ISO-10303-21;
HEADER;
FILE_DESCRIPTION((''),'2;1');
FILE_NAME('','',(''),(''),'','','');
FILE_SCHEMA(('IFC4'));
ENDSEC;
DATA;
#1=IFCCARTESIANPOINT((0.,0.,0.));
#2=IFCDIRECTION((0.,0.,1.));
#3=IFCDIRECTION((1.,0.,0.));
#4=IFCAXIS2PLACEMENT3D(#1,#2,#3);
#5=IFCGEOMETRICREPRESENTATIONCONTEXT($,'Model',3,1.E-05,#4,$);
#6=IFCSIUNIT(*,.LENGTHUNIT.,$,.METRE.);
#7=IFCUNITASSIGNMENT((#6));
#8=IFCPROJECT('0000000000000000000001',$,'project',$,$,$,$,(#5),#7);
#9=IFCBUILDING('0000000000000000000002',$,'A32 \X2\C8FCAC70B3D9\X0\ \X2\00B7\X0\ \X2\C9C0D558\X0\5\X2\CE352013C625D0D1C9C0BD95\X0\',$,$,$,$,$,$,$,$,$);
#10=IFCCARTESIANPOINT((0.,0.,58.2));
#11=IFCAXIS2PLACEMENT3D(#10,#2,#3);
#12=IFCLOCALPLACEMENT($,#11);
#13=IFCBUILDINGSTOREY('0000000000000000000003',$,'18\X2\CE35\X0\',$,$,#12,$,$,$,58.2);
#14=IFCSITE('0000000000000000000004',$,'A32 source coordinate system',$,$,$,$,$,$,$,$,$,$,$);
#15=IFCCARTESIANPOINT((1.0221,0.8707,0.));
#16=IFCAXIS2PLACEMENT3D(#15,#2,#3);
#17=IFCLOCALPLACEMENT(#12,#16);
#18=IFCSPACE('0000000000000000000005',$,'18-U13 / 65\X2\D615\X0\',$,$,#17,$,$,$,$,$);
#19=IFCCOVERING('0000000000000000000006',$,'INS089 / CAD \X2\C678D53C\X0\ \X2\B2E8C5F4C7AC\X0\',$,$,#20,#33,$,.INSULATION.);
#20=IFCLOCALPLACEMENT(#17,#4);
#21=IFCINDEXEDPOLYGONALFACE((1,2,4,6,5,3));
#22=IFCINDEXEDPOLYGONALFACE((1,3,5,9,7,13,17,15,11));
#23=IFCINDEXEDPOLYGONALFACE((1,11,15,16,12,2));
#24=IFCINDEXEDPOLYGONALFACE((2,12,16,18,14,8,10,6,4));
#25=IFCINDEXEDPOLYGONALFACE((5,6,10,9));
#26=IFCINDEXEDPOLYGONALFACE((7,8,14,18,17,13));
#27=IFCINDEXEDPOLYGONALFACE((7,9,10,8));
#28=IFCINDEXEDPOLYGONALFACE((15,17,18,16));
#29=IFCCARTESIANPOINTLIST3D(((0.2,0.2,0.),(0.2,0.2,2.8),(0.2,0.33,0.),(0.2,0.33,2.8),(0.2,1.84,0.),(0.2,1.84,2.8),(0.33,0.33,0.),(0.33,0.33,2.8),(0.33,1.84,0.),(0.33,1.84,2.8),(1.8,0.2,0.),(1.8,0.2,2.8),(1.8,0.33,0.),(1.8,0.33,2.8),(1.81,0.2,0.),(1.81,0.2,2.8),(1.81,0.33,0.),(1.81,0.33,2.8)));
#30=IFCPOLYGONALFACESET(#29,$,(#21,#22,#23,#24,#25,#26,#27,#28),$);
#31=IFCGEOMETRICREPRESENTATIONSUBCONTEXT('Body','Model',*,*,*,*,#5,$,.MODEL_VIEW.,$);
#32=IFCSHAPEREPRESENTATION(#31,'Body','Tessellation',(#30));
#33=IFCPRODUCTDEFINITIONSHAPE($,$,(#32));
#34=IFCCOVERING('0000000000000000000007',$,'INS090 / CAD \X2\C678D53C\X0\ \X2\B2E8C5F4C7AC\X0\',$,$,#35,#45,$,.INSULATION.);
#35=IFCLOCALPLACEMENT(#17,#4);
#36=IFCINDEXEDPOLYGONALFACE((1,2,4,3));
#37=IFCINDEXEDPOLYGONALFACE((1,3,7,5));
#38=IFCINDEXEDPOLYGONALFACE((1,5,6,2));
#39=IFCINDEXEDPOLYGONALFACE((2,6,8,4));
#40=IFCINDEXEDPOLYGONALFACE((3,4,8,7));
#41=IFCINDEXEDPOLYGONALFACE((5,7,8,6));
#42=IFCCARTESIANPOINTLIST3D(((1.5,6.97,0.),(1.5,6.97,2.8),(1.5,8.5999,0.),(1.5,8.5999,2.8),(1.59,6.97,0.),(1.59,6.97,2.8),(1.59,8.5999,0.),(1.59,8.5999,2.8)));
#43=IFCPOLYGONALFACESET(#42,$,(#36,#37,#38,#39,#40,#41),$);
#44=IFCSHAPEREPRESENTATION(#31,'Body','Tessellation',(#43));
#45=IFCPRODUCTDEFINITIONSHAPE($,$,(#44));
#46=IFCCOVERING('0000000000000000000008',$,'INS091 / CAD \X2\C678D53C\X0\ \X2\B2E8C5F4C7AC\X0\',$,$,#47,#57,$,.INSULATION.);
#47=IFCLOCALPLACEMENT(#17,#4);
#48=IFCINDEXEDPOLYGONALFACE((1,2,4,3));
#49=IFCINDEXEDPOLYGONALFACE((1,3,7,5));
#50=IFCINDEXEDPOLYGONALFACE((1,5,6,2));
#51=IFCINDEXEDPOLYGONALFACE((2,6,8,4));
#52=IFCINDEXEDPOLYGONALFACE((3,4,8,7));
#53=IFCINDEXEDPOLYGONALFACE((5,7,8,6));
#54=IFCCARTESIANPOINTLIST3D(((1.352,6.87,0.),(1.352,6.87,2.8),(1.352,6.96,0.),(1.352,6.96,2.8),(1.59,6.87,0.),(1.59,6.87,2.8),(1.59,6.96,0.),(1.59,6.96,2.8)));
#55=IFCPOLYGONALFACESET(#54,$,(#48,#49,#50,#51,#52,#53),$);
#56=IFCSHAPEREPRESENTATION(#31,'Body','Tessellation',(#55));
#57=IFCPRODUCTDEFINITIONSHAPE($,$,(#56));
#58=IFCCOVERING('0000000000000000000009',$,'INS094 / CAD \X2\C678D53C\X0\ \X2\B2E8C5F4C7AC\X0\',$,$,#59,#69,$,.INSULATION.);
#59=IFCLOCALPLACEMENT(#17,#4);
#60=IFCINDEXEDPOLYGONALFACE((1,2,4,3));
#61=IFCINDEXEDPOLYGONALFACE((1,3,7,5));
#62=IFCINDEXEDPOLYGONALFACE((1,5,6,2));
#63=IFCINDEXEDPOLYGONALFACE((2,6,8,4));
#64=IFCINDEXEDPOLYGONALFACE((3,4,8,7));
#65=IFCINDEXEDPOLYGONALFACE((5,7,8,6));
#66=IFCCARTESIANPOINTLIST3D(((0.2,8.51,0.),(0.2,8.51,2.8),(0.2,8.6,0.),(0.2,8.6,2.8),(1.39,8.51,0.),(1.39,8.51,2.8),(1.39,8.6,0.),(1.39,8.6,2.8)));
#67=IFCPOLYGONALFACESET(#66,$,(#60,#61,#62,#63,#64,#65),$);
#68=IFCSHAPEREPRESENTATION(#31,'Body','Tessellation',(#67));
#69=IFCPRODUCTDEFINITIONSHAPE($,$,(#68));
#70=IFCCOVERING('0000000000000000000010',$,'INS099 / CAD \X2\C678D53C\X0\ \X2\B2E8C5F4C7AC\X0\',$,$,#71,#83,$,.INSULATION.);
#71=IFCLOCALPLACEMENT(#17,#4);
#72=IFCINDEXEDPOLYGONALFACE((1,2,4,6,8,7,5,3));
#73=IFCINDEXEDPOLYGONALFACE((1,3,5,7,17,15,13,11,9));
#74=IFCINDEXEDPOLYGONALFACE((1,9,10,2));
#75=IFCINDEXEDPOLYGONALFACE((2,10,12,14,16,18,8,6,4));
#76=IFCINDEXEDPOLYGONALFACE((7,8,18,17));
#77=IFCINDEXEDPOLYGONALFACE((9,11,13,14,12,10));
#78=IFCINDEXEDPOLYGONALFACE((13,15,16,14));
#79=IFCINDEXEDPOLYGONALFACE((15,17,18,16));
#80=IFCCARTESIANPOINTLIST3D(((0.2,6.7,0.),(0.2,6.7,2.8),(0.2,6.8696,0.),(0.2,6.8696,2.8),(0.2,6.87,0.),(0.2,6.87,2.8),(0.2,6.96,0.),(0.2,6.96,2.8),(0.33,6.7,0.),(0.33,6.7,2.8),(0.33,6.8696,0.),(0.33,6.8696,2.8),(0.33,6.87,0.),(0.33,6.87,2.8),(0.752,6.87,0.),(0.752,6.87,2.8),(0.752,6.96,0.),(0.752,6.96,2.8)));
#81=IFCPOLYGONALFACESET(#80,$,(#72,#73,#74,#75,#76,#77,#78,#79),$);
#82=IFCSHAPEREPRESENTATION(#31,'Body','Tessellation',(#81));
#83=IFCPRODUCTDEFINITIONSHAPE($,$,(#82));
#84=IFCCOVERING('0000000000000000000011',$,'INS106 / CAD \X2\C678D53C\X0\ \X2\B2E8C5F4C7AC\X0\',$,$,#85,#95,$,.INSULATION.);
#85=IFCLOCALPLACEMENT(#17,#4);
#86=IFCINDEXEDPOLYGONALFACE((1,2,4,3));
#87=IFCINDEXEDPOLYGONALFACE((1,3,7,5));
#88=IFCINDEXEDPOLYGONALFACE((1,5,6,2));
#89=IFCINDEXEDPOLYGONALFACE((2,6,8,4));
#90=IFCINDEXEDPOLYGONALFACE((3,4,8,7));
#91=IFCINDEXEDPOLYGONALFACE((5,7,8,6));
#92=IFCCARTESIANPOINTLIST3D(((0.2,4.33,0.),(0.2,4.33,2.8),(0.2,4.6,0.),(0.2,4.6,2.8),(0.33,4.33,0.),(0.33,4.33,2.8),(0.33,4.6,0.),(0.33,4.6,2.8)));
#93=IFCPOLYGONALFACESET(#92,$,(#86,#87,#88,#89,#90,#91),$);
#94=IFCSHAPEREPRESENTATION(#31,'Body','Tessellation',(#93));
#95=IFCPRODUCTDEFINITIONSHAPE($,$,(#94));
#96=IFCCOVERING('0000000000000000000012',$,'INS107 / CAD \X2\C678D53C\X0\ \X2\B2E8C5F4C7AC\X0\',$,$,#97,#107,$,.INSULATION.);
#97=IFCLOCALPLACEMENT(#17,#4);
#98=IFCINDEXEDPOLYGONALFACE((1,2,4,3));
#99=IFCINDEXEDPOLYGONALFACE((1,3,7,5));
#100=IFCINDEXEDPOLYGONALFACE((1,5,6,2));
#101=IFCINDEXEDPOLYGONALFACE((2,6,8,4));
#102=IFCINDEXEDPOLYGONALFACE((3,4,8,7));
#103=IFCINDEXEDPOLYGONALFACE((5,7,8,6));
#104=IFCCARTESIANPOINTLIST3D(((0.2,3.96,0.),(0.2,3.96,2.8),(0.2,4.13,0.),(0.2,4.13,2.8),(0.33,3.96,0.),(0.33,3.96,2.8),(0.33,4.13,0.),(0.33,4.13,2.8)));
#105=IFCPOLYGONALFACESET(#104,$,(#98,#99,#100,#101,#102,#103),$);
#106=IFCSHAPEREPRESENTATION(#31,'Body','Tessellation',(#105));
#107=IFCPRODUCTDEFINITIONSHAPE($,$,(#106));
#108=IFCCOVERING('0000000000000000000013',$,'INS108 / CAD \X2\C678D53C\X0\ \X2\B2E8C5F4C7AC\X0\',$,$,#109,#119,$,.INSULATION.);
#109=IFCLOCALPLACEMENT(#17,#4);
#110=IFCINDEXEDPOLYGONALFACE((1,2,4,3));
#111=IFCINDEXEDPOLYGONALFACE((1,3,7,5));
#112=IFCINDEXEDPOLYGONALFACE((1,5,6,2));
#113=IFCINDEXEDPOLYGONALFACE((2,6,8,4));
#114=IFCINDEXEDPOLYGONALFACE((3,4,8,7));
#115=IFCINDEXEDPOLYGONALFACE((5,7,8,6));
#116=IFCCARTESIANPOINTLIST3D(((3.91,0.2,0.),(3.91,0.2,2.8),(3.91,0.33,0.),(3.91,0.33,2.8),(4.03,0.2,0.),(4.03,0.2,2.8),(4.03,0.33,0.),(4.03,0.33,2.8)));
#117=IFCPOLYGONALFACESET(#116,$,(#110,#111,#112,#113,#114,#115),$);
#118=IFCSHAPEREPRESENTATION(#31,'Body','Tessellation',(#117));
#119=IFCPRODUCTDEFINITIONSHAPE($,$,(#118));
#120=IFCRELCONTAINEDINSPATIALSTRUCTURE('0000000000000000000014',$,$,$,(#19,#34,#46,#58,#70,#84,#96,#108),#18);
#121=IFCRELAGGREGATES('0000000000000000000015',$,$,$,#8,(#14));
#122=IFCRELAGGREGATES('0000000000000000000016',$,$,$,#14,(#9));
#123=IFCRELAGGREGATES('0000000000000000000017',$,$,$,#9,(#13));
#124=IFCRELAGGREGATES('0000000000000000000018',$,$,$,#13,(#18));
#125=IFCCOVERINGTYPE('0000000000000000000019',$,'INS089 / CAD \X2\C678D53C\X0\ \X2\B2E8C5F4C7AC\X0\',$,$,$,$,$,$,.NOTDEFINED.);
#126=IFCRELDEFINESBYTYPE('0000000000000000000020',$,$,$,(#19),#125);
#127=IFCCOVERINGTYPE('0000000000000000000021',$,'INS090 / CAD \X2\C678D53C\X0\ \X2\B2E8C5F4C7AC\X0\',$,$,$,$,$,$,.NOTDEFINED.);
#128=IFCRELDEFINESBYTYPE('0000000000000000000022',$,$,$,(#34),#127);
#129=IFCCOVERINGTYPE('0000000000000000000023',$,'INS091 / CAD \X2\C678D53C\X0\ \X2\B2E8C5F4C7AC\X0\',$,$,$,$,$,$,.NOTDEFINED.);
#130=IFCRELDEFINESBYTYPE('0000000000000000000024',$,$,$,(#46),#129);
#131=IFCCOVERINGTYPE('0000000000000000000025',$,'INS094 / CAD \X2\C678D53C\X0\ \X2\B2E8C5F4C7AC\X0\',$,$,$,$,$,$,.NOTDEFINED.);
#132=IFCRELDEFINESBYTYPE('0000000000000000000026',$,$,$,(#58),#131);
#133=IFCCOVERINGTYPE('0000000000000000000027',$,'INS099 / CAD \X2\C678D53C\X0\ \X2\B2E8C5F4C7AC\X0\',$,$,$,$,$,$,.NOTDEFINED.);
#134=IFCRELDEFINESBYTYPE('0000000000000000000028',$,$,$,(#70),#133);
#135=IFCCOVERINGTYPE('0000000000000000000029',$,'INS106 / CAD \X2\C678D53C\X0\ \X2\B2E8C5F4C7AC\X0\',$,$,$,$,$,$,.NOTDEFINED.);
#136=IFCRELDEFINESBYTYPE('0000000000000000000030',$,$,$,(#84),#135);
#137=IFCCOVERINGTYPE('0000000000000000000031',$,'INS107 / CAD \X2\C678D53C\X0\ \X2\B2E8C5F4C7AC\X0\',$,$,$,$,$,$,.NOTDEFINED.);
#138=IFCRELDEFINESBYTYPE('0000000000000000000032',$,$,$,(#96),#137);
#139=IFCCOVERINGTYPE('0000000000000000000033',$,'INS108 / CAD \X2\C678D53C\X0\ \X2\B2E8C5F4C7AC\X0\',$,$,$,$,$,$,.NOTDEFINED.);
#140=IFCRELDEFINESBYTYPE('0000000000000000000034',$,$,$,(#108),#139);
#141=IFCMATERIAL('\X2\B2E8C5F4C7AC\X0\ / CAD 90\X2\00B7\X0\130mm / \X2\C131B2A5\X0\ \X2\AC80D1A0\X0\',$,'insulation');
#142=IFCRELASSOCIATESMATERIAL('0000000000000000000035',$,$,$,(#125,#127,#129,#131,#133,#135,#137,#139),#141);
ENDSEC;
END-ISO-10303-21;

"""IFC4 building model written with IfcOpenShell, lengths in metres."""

from ifc_helpers import new_model, si_unit, frame, origin, origin_with_axes, place, context, subcontext, project, spatial, polyline, outline, extrude, source, transform, mapped, material, type_object, type_shapes, element, save


model = new_model("IFC4")

# Units and contexts
model_context = context("Model", 3, precision=1e-05, world=origin_with_axes())
body_context = subcontext(model_context, "Body", "Model", "MODEL_VIEW")
ifc_project = project(units=[si_unit("LENGTHUNIT", "METRE")], contexts=[model_context])

# Site, building, storey
site = spatial("IfcSite", under=ifc_project, Name="A32 source coordinate system")
building = spatial("IfcBuilding", under=site, Name="A32 주거동 · 지하5층–옥탑지붕")
storey_placement = place(None, frame((0.0, 0.0, 58.2), z_axis=(0.0, 0.0, 1.0), x_axis=(1.0, 0.0, 0.0)))
storey = spatial("IfcBuildingStorey", under=building, at=storey_placement, Name="18층", Elevation=58.2)

# Shared definitions
space_placement = place(storey_placement, frame((1.0221, 0.8707, 0.0), z_axis=(0.0, 0.0, 1.0), x_axis=(1.0, 0.0, 0.0)))
space = spatial("IfcSpace", under=storey, at=space_placement, Name="18-U13 / 65형")

# Coverings
ifc_material = material(Name="단열재 / CAD 90·130mm / 성능 검토", Category="insulation")
covering_type_1 = type_object("IfcCoveringType", Name="INS089 / CAD 외피 단열재", PredefinedType="NOTDEFINED", material=ifc_material)
shared_shape_1 = source(origin(), body_context, "Body", "SweptSolid", [
    extrude(outline(polyline([(0.2, 0.33), (0.2, 1.84), (0.33, 1.84), (0.33, 0.33), (1.8, 0.33), (1.81, 0.33), (1.81, 0.2), (1.8, 0.2), (0.2, 0.2), (0.2, 0.33)])), origin(), (0.0, 0.0, 1.0), 2.8),
])
type_shapes(covering_type_1, [shared_shape_1])
covering_1_placement = place(space_placement, origin_with_axes())
element("IfcCovering", 1, at=covering_1_placement, inside=space, type_object=covering_type_1, Name="INS089 / CAD 외피 단열재", PredefinedType="INSULATION", context=body_context, shape_type="MappedRepresentation", body=[
    mapped(shared_shape_1, transform((0.0, 0.0, 0.0), scale=1.0)),
])
covering_type_2 = type_object("IfcCoveringType", Name="INS090 / CAD 외피 단열재", PredefinedType="NOTDEFINED", material=ifc_material)
shared_shape_2 = source(origin(), body_context, "Body", "SweptSolid", [
    extrude(outline(polyline([(1.59, 6.97), (1.5, 6.97), (1.5, 8.5999), (1.59, 8.5999), (1.59, 6.97)])), origin(), (0.0, 0.0, 1.0), 2.8),
])
type_shapes(covering_type_2, [shared_shape_2])
covering_2_placement = place(space_placement, origin_with_axes())
element("IfcCovering", 2, at=covering_2_placement, inside=space, type_object=covering_type_2, Name="INS090 / CAD 외피 단열재", PredefinedType="INSULATION", context=body_context, shape_type="MappedRepresentation", body=[
    mapped(shared_shape_2, transform((0.0, 0.0, 0.0), scale=1.0)),
])
covering_type_3 = type_object("IfcCoveringType", Name="INS091 / CAD 외피 단열재", PredefinedType="NOTDEFINED", material=ifc_material)
shared_shape_3 = source(origin(), body_context, "Body", "SweptSolid", [
    extrude(outline(polyline([(1.59, 6.96), (1.59, 6.87), (1.352, 6.87), (1.352, 6.96), (1.59, 6.96)])), origin(), (0.0, 0.0, 1.0), 2.8),
])
type_shapes(covering_type_3, [shared_shape_3])
covering_3_placement = place(space_placement, origin_with_axes())
element("IfcCovering", 3, at=covering_3_placement, inside=space, type_object=covering_type_3, Name="INS091 / CAD 외피 단열재", PredefinedType="INSULATION", context=body_context, shape_type="MappedRepresentation", body=[
    mapped(shared_shape_3, transform((0.0, 0.0, 0.0), scale=1.0)),
])
covering_type_4 = type_object("IfcCoveringType", Name="INS094 / CAD 외피 단열재", PredefinedType="NOTDEFINED", material=ifc_material)
shared_shape_4 = source(origin(), body_context, "Body", "SweptSolid", [
    extrude(outline(polyline([(1.39, 8.51), (0.2, 8.51), (0.2, 8.6), (1.39, 8.6), (1.39, 8.51)])), origin(), (0.0, 0.0, 1.0), 2.8),
])
type_shapes(covering_type_4, [shared_shape_4])
covering_4_placement = place(space_placement, origin_with_axes())
element("IfcCovering", 4, at=covering_4_placement, inside=space, type_object=covering_type_4, Name="INS094 / CAD 외피 단열재", PredefinedType="INSULATION", context=body_context, shape_type="MappedRepresentation", body=[
    mapped(shared_shape_4, transform((0.0, 0.0, 0.0), scale=1.0)),
])
covering_type_5 = type_object("IfcCoveringType", Name="INS099 / CAD 외피 단열재", PredefinedType="NOTDEFINED", material=ifc_material)
shared_shape_5 = source(origin(), body_context, "Body", "SweptSolid", [
    extrude(outline(polyline([(0.2, 6.8696), (0.2, 6.87), (0.2, 6.96), (0.752, 6.96), (0.752, 6.87), (0.33, 6.87), (0.33, 6.8696), (0.33, 6.7), (0.2, 6.7), (0.2, 6.8696)])), origin(), (0.0, 0.0, 1.0), 2.8),
])
type_shapes(covering_type_5, [shared_shape_5])
covering_5_placement = place(space_placement, origin_with_axes())
element("IfcCovering", 5, at=covering_5_placement, inside=space, type_object=covering_type_5, Name="INS099 / CAD 외피 단열재", PredefinedType="INSULATION", context=body_context, shape_type="MappedRepresentation", body=[
    mapped(shared_shape_5, transform((0.0, 0.0, 0.0), scale=1.0)),
])
covering_type_6 = type_object("IfcCoveringType", Name="INS106 / CAD 외피 단열재", PredefinedType="NOTDEFINED", material=ifc_material)
shared_shape_6 = source(origin(), body_context, "Body", "SweptSolid", [
    extrude(outline(polyline([(0.33, 4.6), (0.33, 4.33), (0.2, 4.33), (0.2, 4.6), (0.33, 4.6)])), origin(), (0.0, 0.0, 1.0), 2.8),
])
type_shapes(covering_type_6, [shared_shape_6])
covering_6_placement = place(space_placement, origin_with_axes())
element("IfcCovering", 6, at=covering_6_placement, inside=space, type_object=covering_type_6, Name="INS106 / CAD 외피 단열재", PredefinedType="INSULATION", context=body_context, shape_type="MappedRepresentation", body=[
    mapped(shared_shape_6, transform((0.0, 0.0, 0.0), scale=1.0)),
])
covering_type_7 = type_object("IfcCoveringType", Name="INS107 / CAD 외피 단열재", PredefinedType="NOTDEFINED", material=ifc_material)
shared_shape_7 = source(origin(), body_context, "Body", "SweptSolid", [
    extrude(outline(polyline([(0.33, 3.96), (0.2, 3.96), (0.2, 4.13), (0.33, 4.13), (0.33, 3.96)])), origin(), (0.0, 0.0, 1.0), 2.8),
])
type_shapes(covering_type_7, [shared_shape_7])
covering_7_placement = place(space_placement, origin_with_axes())
element("IfcCovering", 7, at=covering_7_placement, inside=space, type_object=covering_type_7, Name="INS107 / CAD 외피 단열재", PredefinedType="INSULATION", context=body_context, shape_type="MappedRepresentation", body=[
    mapped(shared_shape_7, transform((0.0, 0.0, 0.0), scale=1.0)),
])
covering_type_8 = type_object("IfcCoveringType", Name="INS108 / CAD 외피 단열재", PredefinedType="NOTDEFINED", material=ifc_material)
shared_shape_8 = source(origin(), body_context, "Body", "SweptSolid", [
    extrude(outline(polyline([(4.03, 0.2), (3.91, 0.2), (3.91, 0.33), (4.03, 0.33), (4.03, 0.2)])), origin(), (0.0, 0.0, 1.0), 2.8),
])
type_shapes(covering_type_8, [shared_shape_8])
covering_8_placement = place(space_placement, origin_with_axes())
element("IfcCovering", 8, at=covering_8_placement, inside=space, type_object=covering_type_8, Name="INS108 / CAD 외피 단열재", PredefinedType="INSULATION", context=body_context, shape_type="MappedRepresentation", body=[
    mapped(shared_shape_8, transform((0.0, 0.0, 0.0), scale=1.0)),
])

save(model, "model.ifc")
